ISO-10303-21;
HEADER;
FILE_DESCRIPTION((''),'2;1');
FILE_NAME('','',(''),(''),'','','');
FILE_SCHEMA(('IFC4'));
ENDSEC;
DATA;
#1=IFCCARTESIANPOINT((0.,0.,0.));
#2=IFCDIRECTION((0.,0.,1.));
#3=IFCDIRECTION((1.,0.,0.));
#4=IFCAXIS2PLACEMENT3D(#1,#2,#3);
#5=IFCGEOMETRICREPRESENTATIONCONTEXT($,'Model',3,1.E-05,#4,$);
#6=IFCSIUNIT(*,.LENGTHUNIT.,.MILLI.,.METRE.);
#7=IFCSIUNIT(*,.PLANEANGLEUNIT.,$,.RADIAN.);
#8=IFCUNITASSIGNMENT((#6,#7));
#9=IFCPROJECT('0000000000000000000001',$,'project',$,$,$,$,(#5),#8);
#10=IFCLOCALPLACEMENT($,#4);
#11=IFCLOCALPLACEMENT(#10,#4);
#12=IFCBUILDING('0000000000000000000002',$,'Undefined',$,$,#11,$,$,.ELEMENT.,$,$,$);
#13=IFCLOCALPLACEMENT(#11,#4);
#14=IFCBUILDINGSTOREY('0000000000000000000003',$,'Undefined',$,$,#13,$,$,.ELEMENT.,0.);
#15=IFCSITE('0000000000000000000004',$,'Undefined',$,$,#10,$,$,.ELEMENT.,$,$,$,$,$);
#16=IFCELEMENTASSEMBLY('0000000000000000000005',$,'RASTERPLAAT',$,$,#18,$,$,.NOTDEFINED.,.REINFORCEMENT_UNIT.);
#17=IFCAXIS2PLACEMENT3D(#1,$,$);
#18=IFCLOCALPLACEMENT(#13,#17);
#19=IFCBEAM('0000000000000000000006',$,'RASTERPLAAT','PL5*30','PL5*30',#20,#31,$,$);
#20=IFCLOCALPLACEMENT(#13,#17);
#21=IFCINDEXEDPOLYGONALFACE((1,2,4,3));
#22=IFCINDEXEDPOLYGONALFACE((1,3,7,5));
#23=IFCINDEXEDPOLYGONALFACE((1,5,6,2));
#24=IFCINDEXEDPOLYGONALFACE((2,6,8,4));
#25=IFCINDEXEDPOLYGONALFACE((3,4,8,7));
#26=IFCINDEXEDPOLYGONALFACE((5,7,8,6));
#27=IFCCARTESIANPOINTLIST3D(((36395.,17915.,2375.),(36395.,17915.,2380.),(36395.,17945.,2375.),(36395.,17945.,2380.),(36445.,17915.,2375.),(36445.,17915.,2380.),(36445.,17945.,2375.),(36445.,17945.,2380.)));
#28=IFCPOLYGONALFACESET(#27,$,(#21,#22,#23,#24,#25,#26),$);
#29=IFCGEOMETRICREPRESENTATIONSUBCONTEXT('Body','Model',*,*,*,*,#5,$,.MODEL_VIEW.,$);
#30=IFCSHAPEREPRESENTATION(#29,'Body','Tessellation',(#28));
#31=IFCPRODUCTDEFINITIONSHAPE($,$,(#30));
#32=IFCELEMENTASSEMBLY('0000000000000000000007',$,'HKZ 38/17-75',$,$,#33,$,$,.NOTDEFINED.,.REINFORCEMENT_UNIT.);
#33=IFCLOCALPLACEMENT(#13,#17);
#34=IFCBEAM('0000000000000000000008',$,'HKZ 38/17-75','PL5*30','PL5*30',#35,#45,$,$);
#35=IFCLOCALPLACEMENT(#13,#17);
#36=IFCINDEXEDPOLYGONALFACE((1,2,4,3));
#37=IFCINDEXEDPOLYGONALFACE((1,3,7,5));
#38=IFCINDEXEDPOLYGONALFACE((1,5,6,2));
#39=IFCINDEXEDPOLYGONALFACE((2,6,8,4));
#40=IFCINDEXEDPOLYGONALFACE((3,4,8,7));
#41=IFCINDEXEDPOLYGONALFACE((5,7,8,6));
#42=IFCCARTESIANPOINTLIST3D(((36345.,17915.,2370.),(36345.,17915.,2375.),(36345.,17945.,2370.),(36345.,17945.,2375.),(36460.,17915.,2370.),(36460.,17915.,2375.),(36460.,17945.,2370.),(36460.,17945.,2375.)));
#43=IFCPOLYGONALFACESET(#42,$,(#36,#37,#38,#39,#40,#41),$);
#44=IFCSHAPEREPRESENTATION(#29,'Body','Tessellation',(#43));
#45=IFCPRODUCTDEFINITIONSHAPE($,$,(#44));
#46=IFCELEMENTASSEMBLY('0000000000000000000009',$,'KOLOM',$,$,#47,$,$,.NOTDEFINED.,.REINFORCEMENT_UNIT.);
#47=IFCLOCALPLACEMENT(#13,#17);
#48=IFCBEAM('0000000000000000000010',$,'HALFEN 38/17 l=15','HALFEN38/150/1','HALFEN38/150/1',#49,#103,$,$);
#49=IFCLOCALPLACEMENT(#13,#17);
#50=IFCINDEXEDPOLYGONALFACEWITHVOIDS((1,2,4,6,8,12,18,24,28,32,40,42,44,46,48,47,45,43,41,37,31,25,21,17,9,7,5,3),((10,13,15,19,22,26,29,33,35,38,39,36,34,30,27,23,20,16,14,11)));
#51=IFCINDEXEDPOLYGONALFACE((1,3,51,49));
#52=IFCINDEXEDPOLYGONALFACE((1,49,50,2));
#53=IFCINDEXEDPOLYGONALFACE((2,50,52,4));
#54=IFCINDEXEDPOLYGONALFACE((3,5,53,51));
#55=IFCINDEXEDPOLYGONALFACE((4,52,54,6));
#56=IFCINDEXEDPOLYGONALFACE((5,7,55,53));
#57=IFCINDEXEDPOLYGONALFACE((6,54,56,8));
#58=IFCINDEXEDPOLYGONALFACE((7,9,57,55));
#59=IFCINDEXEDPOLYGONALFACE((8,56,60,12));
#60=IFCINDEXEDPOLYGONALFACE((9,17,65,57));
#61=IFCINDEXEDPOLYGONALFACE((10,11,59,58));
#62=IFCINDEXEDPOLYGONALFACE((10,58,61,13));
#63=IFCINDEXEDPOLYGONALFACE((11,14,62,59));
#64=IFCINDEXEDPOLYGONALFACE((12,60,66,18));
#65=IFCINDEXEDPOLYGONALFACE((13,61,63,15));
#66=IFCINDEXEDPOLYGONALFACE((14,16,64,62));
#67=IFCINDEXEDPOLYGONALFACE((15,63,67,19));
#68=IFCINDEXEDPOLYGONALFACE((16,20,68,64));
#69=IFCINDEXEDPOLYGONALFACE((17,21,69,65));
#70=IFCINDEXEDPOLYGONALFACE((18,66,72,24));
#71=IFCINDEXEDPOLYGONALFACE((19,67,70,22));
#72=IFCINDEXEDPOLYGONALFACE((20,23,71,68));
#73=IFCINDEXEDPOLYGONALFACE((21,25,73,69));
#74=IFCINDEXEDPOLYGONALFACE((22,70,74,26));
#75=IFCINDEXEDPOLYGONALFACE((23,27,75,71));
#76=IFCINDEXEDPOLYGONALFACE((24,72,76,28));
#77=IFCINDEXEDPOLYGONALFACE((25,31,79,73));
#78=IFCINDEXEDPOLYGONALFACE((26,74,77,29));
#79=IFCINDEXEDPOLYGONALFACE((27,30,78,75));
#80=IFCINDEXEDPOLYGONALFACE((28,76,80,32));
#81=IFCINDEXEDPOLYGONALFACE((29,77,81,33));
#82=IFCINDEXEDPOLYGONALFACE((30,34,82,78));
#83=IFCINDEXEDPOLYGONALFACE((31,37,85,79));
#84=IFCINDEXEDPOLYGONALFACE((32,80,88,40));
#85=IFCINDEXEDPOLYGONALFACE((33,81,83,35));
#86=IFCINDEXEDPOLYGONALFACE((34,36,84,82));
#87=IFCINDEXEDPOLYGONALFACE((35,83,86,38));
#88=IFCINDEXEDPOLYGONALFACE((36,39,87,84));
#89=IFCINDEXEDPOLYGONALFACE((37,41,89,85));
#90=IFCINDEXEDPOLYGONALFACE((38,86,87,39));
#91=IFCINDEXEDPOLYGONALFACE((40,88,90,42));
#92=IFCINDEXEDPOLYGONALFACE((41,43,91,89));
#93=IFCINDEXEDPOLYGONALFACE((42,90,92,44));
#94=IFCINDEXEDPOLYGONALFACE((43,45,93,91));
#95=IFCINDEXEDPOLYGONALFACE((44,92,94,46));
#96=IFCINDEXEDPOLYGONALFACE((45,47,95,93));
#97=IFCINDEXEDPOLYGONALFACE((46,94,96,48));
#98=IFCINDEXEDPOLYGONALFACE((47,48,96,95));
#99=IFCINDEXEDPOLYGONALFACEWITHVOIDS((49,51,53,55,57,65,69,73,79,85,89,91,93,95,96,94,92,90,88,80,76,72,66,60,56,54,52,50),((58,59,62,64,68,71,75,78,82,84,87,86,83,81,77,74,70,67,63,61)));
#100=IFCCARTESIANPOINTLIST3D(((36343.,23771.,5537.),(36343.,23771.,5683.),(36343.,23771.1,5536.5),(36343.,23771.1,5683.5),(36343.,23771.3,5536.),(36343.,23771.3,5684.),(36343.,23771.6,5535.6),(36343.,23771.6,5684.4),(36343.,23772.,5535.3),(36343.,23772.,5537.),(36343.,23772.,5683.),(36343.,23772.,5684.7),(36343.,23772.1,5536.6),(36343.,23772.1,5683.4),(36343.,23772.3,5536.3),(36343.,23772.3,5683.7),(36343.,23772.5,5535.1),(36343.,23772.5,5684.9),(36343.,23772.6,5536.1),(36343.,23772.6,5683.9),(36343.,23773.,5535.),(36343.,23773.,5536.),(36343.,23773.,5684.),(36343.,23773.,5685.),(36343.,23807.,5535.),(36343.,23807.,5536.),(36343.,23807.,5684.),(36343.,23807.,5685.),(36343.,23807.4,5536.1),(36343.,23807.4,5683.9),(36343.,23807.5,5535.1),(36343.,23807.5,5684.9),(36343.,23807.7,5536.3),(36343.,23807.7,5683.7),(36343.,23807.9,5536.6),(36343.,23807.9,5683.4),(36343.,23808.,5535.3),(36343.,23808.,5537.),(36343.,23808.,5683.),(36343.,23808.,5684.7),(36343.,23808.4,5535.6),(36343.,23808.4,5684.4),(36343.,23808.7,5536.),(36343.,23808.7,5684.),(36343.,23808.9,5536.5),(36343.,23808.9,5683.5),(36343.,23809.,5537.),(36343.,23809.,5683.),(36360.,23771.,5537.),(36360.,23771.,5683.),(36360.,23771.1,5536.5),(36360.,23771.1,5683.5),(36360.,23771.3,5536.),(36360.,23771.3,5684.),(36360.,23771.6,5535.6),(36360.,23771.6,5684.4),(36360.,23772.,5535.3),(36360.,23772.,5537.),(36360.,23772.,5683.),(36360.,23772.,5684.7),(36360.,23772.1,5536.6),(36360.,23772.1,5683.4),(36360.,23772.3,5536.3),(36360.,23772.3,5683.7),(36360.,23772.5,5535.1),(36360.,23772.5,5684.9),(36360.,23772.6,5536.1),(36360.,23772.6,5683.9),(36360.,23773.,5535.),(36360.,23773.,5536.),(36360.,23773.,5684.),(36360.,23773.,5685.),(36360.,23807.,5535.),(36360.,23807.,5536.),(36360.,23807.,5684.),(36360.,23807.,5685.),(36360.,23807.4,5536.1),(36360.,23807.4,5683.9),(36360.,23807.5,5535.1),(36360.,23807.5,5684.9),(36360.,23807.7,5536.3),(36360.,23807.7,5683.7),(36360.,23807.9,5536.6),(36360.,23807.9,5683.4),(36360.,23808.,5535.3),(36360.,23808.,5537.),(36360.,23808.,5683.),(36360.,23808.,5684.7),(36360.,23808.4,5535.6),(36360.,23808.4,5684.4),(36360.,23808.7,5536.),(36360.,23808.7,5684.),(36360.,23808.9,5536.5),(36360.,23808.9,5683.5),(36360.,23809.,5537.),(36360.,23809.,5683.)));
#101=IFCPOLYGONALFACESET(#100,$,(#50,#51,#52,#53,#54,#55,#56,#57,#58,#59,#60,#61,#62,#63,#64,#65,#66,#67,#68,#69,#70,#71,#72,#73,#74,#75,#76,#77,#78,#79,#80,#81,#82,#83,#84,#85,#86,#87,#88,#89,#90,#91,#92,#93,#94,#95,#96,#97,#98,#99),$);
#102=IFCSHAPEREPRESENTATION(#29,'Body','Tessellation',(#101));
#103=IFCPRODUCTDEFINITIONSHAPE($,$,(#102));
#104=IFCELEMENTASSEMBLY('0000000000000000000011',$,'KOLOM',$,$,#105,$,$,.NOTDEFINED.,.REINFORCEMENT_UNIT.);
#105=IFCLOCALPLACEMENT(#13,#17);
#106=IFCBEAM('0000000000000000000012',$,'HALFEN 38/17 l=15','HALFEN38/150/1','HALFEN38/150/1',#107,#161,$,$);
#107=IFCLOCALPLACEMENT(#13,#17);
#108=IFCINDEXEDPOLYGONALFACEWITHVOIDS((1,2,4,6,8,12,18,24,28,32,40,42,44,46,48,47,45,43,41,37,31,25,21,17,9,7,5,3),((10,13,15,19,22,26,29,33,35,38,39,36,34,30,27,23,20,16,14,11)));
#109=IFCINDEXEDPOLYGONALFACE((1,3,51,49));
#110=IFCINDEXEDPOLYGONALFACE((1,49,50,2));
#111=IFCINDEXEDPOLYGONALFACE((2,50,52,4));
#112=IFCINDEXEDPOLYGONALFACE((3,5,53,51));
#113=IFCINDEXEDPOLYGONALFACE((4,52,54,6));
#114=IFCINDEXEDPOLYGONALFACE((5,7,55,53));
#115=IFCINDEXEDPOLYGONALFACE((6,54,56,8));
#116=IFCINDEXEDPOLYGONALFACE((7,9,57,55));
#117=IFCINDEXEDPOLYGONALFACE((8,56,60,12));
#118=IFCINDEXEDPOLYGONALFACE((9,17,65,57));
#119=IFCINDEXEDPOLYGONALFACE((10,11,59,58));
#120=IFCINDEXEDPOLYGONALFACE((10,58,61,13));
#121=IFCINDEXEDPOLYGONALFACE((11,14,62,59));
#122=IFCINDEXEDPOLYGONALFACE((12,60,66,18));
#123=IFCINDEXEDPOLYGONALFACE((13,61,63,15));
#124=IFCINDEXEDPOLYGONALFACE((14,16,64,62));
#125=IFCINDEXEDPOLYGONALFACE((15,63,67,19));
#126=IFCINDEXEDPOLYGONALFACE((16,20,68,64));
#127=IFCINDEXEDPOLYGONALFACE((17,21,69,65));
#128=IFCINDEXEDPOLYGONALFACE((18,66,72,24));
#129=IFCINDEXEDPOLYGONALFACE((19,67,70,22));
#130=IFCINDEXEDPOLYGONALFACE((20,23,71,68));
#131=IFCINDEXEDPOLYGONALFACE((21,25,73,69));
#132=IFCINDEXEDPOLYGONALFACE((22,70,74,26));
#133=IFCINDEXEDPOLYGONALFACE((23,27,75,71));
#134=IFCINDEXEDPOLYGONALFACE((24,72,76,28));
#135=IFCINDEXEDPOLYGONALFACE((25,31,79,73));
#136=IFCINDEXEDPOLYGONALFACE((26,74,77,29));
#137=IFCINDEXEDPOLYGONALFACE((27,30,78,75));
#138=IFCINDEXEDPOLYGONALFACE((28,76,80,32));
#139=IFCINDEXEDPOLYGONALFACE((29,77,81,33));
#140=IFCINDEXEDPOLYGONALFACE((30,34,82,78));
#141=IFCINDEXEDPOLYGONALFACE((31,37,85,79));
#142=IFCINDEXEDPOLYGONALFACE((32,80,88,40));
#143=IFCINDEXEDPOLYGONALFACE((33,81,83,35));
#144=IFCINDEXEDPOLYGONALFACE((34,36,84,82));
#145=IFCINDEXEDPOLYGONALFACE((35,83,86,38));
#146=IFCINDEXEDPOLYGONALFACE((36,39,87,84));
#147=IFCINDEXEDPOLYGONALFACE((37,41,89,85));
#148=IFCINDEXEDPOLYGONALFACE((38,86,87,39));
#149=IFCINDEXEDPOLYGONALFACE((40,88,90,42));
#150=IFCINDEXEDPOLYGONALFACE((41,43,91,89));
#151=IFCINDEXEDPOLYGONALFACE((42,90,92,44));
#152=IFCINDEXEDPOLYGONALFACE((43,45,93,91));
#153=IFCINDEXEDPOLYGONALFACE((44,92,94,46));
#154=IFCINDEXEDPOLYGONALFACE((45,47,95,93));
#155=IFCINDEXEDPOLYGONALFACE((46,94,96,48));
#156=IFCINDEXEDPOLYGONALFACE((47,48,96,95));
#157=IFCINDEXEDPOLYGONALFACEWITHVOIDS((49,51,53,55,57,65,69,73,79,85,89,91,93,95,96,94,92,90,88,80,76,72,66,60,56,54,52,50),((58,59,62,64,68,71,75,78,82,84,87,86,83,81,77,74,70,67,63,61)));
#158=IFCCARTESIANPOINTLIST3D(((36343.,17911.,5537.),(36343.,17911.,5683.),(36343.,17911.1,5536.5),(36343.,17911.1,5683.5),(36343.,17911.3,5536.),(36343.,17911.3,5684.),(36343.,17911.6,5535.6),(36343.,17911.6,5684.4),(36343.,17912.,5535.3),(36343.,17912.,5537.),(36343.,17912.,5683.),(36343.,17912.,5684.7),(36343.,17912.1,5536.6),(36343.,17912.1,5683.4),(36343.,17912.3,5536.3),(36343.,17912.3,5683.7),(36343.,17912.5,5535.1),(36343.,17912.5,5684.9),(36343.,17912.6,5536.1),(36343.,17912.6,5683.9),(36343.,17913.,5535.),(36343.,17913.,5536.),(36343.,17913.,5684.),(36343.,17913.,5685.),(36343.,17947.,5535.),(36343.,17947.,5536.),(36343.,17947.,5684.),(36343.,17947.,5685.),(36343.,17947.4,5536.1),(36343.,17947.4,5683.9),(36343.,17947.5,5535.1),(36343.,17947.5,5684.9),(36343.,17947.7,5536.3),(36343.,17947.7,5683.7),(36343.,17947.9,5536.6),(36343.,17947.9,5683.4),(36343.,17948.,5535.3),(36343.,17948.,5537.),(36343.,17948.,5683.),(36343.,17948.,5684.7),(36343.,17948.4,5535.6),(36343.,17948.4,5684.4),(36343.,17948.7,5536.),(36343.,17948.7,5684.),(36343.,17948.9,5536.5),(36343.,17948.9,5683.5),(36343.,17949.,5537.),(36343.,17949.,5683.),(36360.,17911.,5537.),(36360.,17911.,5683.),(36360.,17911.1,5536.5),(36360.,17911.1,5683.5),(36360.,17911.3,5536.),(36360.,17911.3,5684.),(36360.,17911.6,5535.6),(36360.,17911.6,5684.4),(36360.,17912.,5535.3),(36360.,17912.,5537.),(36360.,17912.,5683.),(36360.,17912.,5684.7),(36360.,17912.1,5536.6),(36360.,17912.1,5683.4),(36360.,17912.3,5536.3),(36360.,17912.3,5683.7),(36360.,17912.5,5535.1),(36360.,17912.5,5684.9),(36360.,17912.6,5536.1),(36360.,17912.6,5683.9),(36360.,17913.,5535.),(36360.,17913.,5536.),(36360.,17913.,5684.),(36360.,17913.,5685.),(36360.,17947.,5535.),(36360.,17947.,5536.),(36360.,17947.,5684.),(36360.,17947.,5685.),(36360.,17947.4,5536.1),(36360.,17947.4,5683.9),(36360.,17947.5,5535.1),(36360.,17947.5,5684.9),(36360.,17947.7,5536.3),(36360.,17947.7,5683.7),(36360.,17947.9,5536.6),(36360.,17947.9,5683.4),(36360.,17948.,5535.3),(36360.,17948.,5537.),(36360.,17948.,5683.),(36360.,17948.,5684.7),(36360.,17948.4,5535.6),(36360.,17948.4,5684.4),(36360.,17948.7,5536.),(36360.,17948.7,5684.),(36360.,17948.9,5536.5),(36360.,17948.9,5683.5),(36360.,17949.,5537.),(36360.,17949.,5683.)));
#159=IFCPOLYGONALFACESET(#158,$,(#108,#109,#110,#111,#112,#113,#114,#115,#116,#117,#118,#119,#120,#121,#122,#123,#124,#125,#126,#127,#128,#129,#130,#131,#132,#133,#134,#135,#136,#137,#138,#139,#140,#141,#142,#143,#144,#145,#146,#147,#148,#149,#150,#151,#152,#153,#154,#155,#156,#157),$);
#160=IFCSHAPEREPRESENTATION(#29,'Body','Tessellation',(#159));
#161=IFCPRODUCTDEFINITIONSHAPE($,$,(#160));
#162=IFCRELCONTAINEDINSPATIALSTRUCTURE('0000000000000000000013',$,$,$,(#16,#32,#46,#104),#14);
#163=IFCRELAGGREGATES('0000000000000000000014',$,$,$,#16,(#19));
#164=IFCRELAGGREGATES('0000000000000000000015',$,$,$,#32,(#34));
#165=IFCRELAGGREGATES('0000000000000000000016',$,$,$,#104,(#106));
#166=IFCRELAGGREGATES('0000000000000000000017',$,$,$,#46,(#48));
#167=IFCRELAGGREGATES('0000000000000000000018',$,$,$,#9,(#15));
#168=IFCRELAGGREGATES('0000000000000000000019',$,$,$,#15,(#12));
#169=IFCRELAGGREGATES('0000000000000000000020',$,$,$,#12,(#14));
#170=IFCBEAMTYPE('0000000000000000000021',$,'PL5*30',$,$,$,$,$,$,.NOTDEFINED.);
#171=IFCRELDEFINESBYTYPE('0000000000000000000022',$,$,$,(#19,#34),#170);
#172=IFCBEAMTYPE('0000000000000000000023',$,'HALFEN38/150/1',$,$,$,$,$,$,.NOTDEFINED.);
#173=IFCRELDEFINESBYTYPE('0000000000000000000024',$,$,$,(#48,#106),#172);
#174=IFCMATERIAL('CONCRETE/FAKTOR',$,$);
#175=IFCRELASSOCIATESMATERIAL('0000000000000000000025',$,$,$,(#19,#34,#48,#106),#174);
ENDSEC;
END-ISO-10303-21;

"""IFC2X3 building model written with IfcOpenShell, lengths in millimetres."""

from ifc_helpers import new_model, si_unit, frame, frame_2d, origin_with_axes, place, context, subcontext, project, spatial, rectangle, hollow_rectangle, extrude, material, type_object, element, aggregate, save


model = new_model("IFC2X3")

# Units and contexts
model_context = context("Model", 3, precision=1e-05, world=origin_with_axes())
body_context = subcontext(model_context, "Body", "Model", "MODEL_VIEW")
ifc_project = project(units=[si_unit("LENGTHUNIT", "METRE", prefix="MILLI"), si_unit("PLANEANGLEUNIT", "RADIAN")], contexts=[model_context])

# Site, building, storey
site_placement = place(None, origin_with_axes())
site = spatial("IfcSite", under=ifc_project, at=site_placement, Name="Undefined", CompositionType="ELEMENT")
building_placement = place(site_placement, origin_with_axes())
building = spatial("IfcBuilding", under=site, at=building_placement, Name="Undefined", CompositionType="ELEMENT")
storey_placement = place(building_placement, origin_with_axes())
storey = spatial("IfcBuildingStorey", under=building, at=storey_placement, Name="Undefined", CompositionType="ELEMENT", Elevation=0.0)

# Element assemblies, beams
ifc_material_1 = material(Name="CONCRETE/FAKTOR")
beam_type_1 = type_object("IfcBeamType", Name="PL5*30", PredefinedType="NOTDEFINED")
assembly_1_placement = place(storey_placement, origin_with_axes())
assembly_1 = element("IfcElementAssembly", 1, at=assembly_1_placement, inside=storey, Name="RASTERPLAAT", AssemblyPlace="NOTDEFINED", PredefinedType="REINFORCEMENT_UNIT")
beam_1_placement = place(assembly_1_placement, frame((36395.0, 17930.0, 2377.5), z_axis=(0.0, -1.0, 0.0), x_axis=(1.0, 0.0, 0.0)))
beam_1 = element("IfcBeam", 2, at=beam_1_placement, type_object=beam_type_1, material=ifc_material_1, Name="RASTERPLAAT", Description="PL5*30", ObjectType="PL5*30", context=body_context, shape_type="SweptSolid", body=[
    extrude(rectangle(XDim=5.0, YDim=30.0, at=frame_2d((0.0, 0.0), x_axis=(1.0, 0.0))), frame((50.0, 0.0, 0.0), z_axis=(-1.0, 0.0, 0.0), x_axis=(0.0, -1.0, 0.0)), (0.0, 0.0, 1.0), 50.0),
])
aggregate(assembly_1, [beam_1])
assembly_2_placement = place(storey_placement, origin_with_axes())
assembly_2 = element("IfcElementAssembly", 3, at=assembly_2_placement, inside=storey, Name="HKZ 38/17-75", AssemblyPlace="NOTDEFINED", PredefinedType="REINFORCEMENT_UNIT")
beam_2_placement = place(assembly_2_placement, frame((36345.0, 17930.0, 2372.5), z_axis=(0.0, -1.0, 0.0), x_axis=(1.0, 0.0, 0.0)))
beam_2 = element("IfcBeam", 4, at=beam_2_placement, type_object=beam_type_1, material=ifc_material_1, Name="HKZ 38/17-75", Description="PL5*30", ObjectType="PL5*30", context=body_context, shape_type="SweptSolid", body=[
    extrude(rectangle(XDim=5.0, YDim=30.0, at=frame_2d((0.0, 0.0), x_axis=(1.0, 0.0))), frame((115.0, 0.0, 0.0), z_axis=(-1.0, 0.0, 0.0), x_axis=(0.0, -1.0, 0.0)), (0.0, 0.0, 1.0), 115.0),
])
aggregate(assembly_2, [beam_2])
assembly_3_placement = place(storey_placement, origin_with_axes())
assembly_3 = element("IfcElementAssembly", 5, at=assembly_3_placement, inside=storey, Name="KOLOM", AssemblyPlace="NOTDEFINED", PredefinedType="REINFORCEMENT_UNIT")
beam_type_2 = type_object("IfcBeamType", Name="HALFEN38/150/1", PredefinedType="NOTDEFINED")
beam_3_placement = place(assembly_3_placement, frame((36360.0, 23790.0, 5610.0), z_axis=(0.0, -1.0, 0.0), x_axis=(-1.0, 0.0, 0.0)))
beam_3 = element("IfcBeam", 6, at=beam_3_placement, type_object=beam_type_2, material=ifc_material_1, Name="HALFEN 38/17 l=15", Description="HALFEN38/150/1", ObjectType="HALFEN38/150/1", context=body_context, shape_type="SweptSolid", body=[
    extrude(hollow_rectangle(XDim=150.0, YDim=38.0, WallThickness=1.0, InnerFilletRadius=1.0, OuterFilletRadius=2.0, at=frame_2d((0.0, 0.0), x_axis=(1.0, 0.0))), frame((17.0, 0.0, 0.0), z_axis=(-1.0, 0.0, 0.0), x_axis=(0.0, -1.0, 0.0)), (0.0, 0.0, 1.0), 17.0),
])
assembly_4_placement = place(storey_placement, origin_with_axes())
assembly_4 = element("IfcElementAssembly", 7, at=assembly_4_placement, inside=storey, Name="KOLOM", AssemblyPlace="NOTDEFINED", PredefinedType="REINFORCEMENT_UNIT")
beam_4_placement = place(assembly_4_placement, frame((36360.0, 17930.0, 5610.0), z_axis=(0.0, 1.0, 0.0), x_axis=(-1.0, 0.0, 0.0)))
beam_4 = element("IfcBeam", 8, at=beam_4_placement, type_object=beam_type_2, material=ifc_material_1, Name="HALFEN 38/17 l=15", Description="HALFEN38/150/1", ObjectType="HALFEN38/150/1", context=body_context, shape_type="SweptSolid", body=[
    extrude(hollow_rectangle(XDim=150.0, YDim=38.0, WallThickness=1.0, InnerFilletRadius=1.0, OuterFilletRadius=2.0, at=frame_2d((0.0, 0.0), x_axis=(1.0, 0.0))), frame((17.0, 0.0, 0.0), z_axis=(-1.0, 0.0, 0.0), x_axis=(0.0, -1.0, 0.0)), (0.0, 0.0, 1.0), 17.0),
])

aggregate(assembly_4, [beam_4])
aggregate(assembly_3, [beam_3])

save(model, "model.ifc")
